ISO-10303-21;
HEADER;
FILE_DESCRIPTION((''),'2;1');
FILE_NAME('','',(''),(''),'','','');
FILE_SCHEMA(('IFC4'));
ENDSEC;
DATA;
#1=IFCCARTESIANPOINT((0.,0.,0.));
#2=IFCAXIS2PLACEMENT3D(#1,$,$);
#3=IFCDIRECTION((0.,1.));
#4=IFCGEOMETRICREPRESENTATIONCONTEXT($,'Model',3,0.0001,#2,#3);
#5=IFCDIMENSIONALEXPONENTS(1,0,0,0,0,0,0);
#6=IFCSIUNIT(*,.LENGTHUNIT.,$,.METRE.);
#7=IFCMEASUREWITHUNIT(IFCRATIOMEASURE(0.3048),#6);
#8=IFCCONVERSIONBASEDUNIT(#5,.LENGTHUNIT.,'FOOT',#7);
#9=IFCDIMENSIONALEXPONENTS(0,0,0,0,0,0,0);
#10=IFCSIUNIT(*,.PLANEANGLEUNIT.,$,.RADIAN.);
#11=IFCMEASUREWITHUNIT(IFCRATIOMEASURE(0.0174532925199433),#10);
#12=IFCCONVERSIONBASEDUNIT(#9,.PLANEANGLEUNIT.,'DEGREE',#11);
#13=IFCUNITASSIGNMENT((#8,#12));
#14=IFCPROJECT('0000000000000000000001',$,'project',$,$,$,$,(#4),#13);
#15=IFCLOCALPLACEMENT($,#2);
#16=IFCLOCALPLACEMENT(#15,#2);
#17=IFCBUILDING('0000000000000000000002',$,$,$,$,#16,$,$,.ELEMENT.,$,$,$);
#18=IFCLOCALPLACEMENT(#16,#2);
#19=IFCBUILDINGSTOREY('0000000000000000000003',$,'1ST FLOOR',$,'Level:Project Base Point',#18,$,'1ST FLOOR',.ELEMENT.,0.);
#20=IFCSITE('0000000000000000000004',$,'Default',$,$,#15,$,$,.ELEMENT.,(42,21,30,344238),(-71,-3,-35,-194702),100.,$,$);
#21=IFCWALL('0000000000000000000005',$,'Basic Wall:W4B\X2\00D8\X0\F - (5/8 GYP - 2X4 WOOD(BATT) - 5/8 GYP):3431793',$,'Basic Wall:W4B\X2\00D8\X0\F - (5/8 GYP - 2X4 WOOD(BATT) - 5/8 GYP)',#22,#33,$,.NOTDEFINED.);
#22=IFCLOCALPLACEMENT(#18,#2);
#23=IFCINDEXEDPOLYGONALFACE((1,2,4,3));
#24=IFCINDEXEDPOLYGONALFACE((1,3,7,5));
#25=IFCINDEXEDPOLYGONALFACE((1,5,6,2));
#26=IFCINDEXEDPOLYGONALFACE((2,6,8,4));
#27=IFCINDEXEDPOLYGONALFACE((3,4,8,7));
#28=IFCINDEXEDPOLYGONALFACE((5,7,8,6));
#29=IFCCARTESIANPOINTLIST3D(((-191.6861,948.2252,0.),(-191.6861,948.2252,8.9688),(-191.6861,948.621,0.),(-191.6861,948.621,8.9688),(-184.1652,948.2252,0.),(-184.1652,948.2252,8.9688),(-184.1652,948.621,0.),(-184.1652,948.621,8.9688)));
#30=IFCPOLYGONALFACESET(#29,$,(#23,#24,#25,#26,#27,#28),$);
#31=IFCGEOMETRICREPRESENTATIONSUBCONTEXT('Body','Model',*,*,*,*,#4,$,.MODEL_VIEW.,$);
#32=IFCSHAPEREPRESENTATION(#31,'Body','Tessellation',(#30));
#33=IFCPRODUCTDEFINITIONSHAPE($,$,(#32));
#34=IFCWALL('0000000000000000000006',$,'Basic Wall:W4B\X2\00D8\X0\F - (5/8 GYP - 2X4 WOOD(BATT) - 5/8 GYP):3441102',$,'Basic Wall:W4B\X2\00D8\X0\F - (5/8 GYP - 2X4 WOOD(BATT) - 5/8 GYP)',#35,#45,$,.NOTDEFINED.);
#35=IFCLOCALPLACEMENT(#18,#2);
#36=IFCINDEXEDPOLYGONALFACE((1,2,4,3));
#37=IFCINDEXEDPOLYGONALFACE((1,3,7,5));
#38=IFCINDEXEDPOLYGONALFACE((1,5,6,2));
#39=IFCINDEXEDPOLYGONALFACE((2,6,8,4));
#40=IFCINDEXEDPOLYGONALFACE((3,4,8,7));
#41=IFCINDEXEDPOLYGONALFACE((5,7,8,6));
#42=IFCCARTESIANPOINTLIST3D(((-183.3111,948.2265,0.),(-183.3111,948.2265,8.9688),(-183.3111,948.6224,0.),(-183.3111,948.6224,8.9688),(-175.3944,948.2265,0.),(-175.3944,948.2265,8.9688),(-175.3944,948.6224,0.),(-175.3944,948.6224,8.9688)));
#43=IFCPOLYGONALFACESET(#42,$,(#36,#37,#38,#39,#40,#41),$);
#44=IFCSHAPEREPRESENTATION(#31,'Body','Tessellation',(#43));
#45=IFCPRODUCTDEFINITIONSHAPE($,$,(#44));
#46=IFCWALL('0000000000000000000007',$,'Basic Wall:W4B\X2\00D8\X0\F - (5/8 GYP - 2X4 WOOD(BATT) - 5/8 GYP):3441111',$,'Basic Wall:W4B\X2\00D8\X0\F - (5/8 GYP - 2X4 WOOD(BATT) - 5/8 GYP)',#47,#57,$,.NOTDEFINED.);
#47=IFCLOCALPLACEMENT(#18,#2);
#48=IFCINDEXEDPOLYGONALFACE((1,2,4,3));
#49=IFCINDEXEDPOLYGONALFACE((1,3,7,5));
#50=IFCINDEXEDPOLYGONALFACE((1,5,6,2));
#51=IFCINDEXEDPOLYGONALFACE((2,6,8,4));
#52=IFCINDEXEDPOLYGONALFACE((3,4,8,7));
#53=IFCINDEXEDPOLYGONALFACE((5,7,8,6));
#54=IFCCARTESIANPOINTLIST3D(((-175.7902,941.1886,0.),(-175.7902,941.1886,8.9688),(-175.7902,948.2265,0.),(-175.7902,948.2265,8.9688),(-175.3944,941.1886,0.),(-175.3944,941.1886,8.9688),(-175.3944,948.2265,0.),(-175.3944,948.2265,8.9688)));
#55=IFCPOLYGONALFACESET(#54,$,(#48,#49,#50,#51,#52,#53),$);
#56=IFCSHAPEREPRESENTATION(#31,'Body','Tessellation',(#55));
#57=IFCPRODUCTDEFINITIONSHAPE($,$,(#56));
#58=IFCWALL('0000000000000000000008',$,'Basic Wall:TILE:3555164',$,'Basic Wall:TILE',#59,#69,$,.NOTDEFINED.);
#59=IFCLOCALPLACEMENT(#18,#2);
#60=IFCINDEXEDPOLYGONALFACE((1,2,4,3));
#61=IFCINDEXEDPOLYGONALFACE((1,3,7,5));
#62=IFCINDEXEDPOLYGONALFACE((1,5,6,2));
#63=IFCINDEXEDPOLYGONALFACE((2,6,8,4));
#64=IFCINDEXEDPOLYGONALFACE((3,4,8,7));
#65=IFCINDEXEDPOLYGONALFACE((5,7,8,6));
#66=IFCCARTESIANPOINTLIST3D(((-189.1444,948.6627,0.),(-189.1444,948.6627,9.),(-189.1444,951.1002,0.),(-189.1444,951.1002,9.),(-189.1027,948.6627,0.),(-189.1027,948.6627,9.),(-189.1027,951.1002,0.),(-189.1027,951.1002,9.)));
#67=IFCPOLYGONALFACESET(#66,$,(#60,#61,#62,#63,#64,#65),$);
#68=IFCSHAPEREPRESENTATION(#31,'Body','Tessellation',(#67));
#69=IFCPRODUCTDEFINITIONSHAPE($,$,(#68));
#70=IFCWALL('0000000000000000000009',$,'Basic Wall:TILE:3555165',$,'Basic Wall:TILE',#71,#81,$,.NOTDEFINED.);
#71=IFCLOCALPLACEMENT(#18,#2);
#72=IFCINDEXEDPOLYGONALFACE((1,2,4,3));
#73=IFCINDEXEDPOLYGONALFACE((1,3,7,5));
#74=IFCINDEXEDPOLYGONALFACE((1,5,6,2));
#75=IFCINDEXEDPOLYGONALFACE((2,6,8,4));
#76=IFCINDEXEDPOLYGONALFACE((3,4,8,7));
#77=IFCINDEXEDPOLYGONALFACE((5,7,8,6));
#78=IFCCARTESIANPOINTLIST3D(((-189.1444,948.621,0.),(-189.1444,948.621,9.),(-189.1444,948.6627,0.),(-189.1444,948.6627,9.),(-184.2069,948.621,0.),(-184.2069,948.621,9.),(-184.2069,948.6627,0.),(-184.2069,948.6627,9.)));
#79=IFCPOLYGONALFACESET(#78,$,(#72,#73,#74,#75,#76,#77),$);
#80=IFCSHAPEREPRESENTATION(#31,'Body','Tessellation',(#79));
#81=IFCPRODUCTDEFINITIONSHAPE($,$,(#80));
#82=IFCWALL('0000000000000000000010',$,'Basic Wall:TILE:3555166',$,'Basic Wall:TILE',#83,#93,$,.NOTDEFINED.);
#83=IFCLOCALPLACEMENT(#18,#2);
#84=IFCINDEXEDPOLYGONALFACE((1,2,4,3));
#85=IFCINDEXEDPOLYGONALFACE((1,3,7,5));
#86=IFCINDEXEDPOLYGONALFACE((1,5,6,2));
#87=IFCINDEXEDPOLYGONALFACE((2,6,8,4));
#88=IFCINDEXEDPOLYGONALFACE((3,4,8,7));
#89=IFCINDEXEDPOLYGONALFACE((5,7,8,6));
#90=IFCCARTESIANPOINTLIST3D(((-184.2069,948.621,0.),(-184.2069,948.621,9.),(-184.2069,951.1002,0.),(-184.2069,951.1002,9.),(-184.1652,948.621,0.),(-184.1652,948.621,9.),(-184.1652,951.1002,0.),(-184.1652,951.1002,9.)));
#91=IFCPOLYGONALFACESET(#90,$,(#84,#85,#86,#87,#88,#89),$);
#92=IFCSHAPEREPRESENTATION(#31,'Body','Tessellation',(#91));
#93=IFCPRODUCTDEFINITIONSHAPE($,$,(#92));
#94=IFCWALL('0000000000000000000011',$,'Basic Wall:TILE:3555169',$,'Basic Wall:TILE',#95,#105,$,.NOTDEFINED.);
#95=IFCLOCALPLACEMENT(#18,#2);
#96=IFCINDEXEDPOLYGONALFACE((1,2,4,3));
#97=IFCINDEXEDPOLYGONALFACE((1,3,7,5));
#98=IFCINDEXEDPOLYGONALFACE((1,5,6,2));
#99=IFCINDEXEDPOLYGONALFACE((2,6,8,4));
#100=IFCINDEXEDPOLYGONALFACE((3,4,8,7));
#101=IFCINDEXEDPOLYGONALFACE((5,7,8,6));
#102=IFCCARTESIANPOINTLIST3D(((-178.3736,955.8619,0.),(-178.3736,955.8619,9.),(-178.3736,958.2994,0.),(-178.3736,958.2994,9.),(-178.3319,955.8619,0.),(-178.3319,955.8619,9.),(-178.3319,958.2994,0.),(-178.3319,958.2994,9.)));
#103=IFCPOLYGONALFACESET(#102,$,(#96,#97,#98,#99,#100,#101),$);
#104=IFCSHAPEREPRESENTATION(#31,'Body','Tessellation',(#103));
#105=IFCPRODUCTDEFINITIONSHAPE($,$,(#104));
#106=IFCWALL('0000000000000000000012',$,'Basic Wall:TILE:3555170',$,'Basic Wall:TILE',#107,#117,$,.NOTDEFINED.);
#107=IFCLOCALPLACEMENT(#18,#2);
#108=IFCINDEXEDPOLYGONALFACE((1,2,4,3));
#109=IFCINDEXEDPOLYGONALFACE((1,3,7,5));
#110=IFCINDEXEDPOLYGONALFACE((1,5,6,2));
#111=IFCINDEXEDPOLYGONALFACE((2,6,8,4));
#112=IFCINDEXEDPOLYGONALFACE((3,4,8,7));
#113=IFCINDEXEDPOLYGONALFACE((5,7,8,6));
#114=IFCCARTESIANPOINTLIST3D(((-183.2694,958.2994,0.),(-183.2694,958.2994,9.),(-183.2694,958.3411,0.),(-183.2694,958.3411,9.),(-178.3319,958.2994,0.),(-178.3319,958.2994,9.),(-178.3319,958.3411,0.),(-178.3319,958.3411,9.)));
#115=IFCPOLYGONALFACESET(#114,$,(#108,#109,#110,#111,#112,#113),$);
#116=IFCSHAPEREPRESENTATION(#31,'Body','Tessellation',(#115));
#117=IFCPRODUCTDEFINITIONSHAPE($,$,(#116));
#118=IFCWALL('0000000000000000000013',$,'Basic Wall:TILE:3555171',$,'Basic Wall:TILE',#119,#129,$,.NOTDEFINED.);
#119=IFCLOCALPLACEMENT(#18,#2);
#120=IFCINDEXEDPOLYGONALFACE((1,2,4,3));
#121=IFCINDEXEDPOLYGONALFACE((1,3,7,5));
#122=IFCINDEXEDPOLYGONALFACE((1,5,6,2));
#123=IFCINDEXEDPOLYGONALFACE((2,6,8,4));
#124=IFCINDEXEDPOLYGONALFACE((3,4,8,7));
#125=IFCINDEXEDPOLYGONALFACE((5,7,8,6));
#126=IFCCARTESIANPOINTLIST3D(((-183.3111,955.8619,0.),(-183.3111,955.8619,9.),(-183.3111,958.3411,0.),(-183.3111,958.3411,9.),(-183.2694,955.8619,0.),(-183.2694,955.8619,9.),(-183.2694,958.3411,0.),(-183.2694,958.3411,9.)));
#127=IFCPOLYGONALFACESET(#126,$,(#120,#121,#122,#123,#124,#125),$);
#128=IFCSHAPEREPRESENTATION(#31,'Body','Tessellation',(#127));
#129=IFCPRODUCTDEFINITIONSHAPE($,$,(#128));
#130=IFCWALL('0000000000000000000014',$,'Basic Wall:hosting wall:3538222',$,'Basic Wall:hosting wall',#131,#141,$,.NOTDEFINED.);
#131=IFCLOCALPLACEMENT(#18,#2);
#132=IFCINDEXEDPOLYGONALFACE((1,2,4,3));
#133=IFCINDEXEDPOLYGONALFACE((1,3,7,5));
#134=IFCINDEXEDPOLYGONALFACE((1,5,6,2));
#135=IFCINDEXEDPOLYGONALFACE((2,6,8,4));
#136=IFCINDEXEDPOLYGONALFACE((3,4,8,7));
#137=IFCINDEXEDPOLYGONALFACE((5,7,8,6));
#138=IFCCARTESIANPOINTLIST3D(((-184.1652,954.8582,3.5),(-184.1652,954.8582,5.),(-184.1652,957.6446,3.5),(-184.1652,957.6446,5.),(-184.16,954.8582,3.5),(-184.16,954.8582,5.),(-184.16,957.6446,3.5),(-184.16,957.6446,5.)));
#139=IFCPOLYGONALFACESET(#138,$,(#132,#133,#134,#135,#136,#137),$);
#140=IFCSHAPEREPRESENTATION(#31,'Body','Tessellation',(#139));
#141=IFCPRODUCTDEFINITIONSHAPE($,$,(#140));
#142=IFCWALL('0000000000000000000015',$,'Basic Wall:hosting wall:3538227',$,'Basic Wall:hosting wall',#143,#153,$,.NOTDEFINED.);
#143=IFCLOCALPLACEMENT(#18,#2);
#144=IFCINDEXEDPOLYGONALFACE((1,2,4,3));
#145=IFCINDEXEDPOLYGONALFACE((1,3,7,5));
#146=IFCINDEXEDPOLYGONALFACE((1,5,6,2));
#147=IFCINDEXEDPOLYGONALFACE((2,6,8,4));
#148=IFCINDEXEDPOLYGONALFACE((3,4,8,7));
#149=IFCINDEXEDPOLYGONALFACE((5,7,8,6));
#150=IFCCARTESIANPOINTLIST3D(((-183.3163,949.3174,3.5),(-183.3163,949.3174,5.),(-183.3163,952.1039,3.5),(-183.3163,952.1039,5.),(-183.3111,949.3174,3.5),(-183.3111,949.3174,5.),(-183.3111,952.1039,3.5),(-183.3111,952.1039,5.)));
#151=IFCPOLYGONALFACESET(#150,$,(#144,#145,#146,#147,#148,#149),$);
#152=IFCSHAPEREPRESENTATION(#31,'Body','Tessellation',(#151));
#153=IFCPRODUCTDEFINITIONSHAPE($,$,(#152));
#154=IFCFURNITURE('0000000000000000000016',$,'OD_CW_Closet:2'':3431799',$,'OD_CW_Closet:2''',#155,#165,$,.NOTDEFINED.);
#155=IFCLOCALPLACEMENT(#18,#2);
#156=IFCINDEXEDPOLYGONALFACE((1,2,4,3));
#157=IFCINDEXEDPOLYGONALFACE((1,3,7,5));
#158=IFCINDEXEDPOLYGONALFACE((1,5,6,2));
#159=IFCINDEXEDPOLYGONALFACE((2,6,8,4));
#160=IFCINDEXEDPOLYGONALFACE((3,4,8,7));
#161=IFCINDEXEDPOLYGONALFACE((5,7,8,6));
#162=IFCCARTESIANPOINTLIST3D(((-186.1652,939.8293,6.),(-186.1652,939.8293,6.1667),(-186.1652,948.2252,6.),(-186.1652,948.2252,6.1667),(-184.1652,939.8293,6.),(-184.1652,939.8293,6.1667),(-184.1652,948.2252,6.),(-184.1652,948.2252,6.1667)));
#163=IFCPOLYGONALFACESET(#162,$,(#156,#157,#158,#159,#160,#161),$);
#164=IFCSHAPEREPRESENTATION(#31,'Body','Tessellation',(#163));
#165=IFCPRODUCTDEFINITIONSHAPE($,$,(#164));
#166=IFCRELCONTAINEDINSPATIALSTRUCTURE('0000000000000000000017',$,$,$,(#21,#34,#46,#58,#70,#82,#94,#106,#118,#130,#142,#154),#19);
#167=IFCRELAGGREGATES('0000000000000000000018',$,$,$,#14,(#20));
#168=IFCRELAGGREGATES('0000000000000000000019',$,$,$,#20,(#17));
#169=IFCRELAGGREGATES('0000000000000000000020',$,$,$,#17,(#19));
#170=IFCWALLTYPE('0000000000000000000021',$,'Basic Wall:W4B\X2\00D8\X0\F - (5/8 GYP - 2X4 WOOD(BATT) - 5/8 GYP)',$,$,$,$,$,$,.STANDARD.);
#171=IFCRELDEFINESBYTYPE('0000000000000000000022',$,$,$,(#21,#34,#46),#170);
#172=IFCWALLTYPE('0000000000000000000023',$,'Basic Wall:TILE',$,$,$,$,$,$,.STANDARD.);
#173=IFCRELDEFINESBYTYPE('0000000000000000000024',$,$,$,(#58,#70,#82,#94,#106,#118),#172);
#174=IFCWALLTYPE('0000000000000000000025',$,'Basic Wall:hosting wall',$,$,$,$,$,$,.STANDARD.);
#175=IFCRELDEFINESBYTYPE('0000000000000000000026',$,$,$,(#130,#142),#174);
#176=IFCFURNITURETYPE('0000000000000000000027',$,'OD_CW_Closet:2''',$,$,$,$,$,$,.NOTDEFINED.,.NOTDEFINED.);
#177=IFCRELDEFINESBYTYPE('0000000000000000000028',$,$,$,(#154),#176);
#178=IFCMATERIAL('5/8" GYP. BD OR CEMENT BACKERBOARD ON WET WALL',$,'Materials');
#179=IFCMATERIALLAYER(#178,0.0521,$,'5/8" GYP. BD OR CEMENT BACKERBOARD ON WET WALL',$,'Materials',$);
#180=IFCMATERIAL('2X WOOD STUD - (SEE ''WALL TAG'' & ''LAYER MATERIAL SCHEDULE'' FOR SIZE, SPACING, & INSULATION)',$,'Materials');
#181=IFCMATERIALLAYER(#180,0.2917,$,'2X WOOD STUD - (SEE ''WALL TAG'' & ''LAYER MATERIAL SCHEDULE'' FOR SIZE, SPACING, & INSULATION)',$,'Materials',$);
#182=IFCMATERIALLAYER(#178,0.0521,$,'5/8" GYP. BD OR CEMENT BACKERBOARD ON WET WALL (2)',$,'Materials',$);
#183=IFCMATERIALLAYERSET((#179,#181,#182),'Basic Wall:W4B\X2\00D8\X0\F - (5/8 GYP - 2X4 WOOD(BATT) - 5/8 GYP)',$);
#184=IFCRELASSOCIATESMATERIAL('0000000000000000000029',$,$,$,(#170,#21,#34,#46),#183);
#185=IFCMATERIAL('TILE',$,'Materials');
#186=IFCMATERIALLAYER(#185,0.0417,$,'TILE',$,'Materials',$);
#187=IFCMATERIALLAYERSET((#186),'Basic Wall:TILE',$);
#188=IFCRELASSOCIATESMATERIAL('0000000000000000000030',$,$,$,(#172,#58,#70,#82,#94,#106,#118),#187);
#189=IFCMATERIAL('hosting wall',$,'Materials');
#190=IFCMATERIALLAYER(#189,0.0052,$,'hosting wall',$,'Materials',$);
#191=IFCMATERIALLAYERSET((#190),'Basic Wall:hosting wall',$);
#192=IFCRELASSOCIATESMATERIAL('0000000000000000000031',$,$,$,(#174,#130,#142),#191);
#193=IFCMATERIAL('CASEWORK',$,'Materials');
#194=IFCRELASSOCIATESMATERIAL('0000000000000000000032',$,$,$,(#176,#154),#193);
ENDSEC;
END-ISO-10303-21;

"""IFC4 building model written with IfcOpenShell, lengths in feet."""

from ifc_helpers import new_model, entity, si_unit, converted_unit, direction, frame, frame_2d, origin, place, context, subcontext, project, spatial, rectangle, extrude, source, transform, mapped, material, layer, layer_set, layer_usage, type_object, type_shapes, element, save


model = new_model("IFC4")

# Units and contexts
model_context = context("Model", 3, precision=0.0001, world=origin(), true_north=direction((0.0, 1.0)))
body_context = subcontext(model_context, "Body", "Model", "MODEL_VIEW")
ifc_project = project(units=[converted_unit("LENGTHUNIT", "FOOT", entity("IfcRatioMeasure", 0.3048), si_unit("LENGTHUNIT", "METRE"), dimensions=[1, 0, 0, 0, 0, 0, 0]), converted_unit("PLANEANGLEUNIT", "DEGREE", entity("IfcRatioMeasure", 0.0174532925199433), si_unit("PLANEANGLEUNIT", "RADIAN"), dimensions=[0, 0, 0, 0, 0, 0, 0])], contexts=[model_context])

# Site, building, storey
site_placement = place(None, origin())
site = spatial("IfcSite", under=ifc_project, at=site_placement, Name="Default", CompositionType="ELEMENT", RefLatitude=(42, 21, 30, 344238), RefLongitude=(-71, -3, -35, -194702), RefElevation=100.0)
building_placement = place(site_placement, origin())
building = spatial("IfcBuilding", under=site, at=building_placement, CompositionType="ELEMENT")
storey_placement = place(building_placement, origin())
storey = spatial("IfcBuildingStorey", under=building, at=storey_placement, Name="1ST FLOOR", ObjectType="Level:Project Base Point", LongName="1ST FLOOR", CompositionType="ELEMENT", Elevation=0.0)

# Walls
ifc_material_1 = material(Name="5/8\" GYP. BD OR CEMENT BACKERBOARD ON WET WALL", Category="Materials")
ifc_layer_1 = layer(ifc_material_1, 0.0521, Name="5/8\" GYP. BD OR CEMENT BACKERBOARD ON WET WALL", Category="Materials")
ifc_material_2 = material(Name="2X WOOD STUD - (SEE 'WALL TAG' & 'LAYER MATERIAL SCHEDULE' FOR SIZE, SPACING, & INSULATION)", Category="Materials")
ifc_layer_2 = layer(ifc_material_2, 0.2917, Name="2X WOOD STUD - (SEE 'WALL TAG' & 'LAYER MATERIAL SCHEDULE' FOR SIZE, SPACING, & INSULATION)", Category="Materials")
ifc_layer_3 = layer(ifc_material_1, 0.0521, Name="5/8\" GYP. BD OR CEMENT BACKERBOARD ON WET WALL (2)", Category="Materials")
ifc_layer_set_1 = layer_set([ifc_layer_1, ifc_layer_2, ifc_layer_3], Name="Basic Wall:W4BØF - (5/8 GYP - 2X4 WOOD(BATT) - 5/8 GYP)")
ifc_layer_usage_1 = layer_usage(ifc_layer_set_1, "AXIS2", "NEGATIVE", 0.1979)
wall_type_1 = type_object("IfcWallType", Name="Basic Wall:W4BØF - (5/8 GYP - 2X4 WOOD(BATT) - 5/8 GYP)", PredefinedType="STANDARD", material=ifc_layer_set_1)
wall_1_placement = place(storey_placement, frame((-184.1652, 948.4231, 0.0), z_axis=(0.0, 0.0, 1.0), x_axis=(-1.0, 0.0, 0.0)))
element("IfcWall", 1, at=wall_1_placement, inside=storey, type_object=wall_type_1, material=ifc_layer_usage_1, Name="Basic Wall:W4BØF - (5/8 GYP - 2X4 WOOD(BATT) - 5/8 GYP):3431793", ObjectType="Basic Wall:W4BØF - (5/8 GYP - 2X4 WOOD(BATT) - 5/8 GYP)", PredefinedType="NOTDEFINED", context=body_context, shape_type="SweptSolid", body=[
    extrude(rectangle(XDim=7.5208, YDim=0.3958, at=frame_2d((3.7604, 0.0), x_axis=(-1.0, 0.0))), origin(), (0.0, 0.0, 1.0), 8.9688),
])
ifc_layer_usage_2 = layer_usage(ifc_layer_set_1, "AXIS2", "POSITIVE", -0.1979)
wall_2_placement = place(storey_placement, frame((-183.3111, 948.4244, 0.0)))
element("IfcWall", 2, at=wall_2_placement, inside=storey, type_object=wall_type_1, material=ifc_layer_usage_2, Name="Basic Wall:W4BØF - (5/8 GYP - 2X4 WOOD(BATT) - 5/8 GYP):3441102", ObjectType="Basic Wall:W4BØF - (5/8 GYP - 2X4 WOOD(BATT) - 5/8 GYP)", PredefinedType="NOTDEFINED", context=body_context, shape_type="SweptSolid", body=[
    extrude(rectangle(XDim=7.9167, YDim=0.3958, at=frame_2d((3.9583, 0.0), x_axis=(-1.0, 0.0))), origin(), (0.0, 0.0, 1.0), 8.9688),
])

# Walls
ifc_layer_usage_3 = layer_usage(ifc_layer_set_1, "AXIS2", "POSITIVE", -0.1979)
wall_3_placement = place(storey_placement, frame((-175.5923, 941.1886, 0.0), z_axis=(0.0, 0.0, 1.0), x_axis=(0.0, 1.0, 0.0)))
element("IfcWall", 3, at=wall_3_placement, inside=storey, type_object=wall_type_1, material=ifc_layer_usage_3, Name="Basic Wall:W4BØF - (5/8 GYP - 2X4 WOOD(BATT) - 5/8 GYP):3441111", ObjectType="Basic Wall:W4BØF - (5/8 GYP - 2X4 WOOD(BATT) - 5/8 GYP)", PredefinedType="NOTDEFINED", context=body_context, shape_type="SweptSolid", body=[
    extrude(rectangle(XDim=7.038, YDim=0.3958, at=frame_2d((3.519, 0.0), x_axis=(-1.0, 0.0))), origin(), (0.0, 0.0, 1.0), 8.9688),
])
ifc_material_3 = material(Name="TILE", Category="Materials")
ifc_layer_4 = layer(ifc_material_3, 0.0417, Name="TILE", Category="Materials")
ifc_layer_set_2 = layer_set([ifc_layer_4], Name="Basic Wall:TILE")
ifc_layer_usage_4 = layer_usage(ifc_layer_set_2, "AXIS2", "POSITIVE", -0.0208)
wall_type_2 = type_object("IfcWallType", Name="Basic Wall:TILE", PredefinedType="STANDARD", material=ifc_layer_set_2)
wall_4_placement = place(storey_placement, frame((-189.1236, 951.1002, 0.0), z_axis=(0.0, 0.0, 1.0), x_axis=(0.0, -1.0, 0.0)))
element("IfcWall", 4, at=wall_4_placement, inside=storey, type_object=wall_type_2, material=ifc_layer_usage_4, Name="Basic Wall:TILE:3555164", ObjectType="Basic Wall:TILE", PredefinedType="NOTDEFINED", context=body_context, shape_type="SweptSolid", body=[
    extrude(rectangle(XDim=2.4375, YDim=0.0417, at=frame_2d((1.2187, 0.0), x_axis=(-1.0, 0.0))), origin(), (0.0, 0.0, 1.0), 9.0),
])
ifc_layer_usage_5 = layer_usage(ifc_layer_set_2, "AXIS2", "POSITIVE", -0.0208)
wall_5_placement = place(storey_placement, frame((-189.1444, 948.6418, 0.0)))
element("IfcWall", 5, at=wall_5_placement, inside=storey, type_object=wall_type_2, material=ifc_layer_usage_5, Name="Basic Wall:TILE:3555165", ObjectType="Basic Wall:TILE", PredefinedType="NOTDEFINED", context=body_context, shape_type="SweptSolid", body=[
    extrude(rectangle(XDim=4.9375, YDim=0.0417, at=frame_2d((2.4688, 0.0), x_axis=(-1.0, 0.0))), origin(), (0.0, 0.0, 1.0), 9.0),
])
ifc_layer_usage_6 = layer_usage(ifc_layer_set_2, "AXIS2", "POSITIVE", -0.0208)
wall_6_placement = place(storey_placement, frame((-184.1861, 948.621, 0.0), z_axis=(0.0, 0.0, 1.0), x_axis=(0.0, 1.0, 0.0)))
element("IfcWall", 6, at=wall_6_placement, inside=storey, type_object=wall_type_2, material=ifc_layer_usage_6, Name="Basic Wall:TILE:3555166", ObjectType="Basic Wall:TILE", PredefinedType="NOTDEFINED", context=body_context, shape_type="SweptSolid", body=[
    extrude(rectangle(XDim=2.4792, YDim=0.0417, at=frame_2d((1.2396, 0.0), x_axis=(-1.0, 0.0))), origin(), (0.0, 0.0, 1.0), 9.0),
])
ifc_layer_usage_7 = layer_usage(ifc_layer_set_2, "AXIS2", "POSITIVE", -0.0208)
wall_7_placement = place(storey_placement, frame((-178.3527, 955.8619, 0.0), z_axis=(0.0, 0.0, 1.0), x_axis=(0.0, 1.0, 0.0)))
element("IfcWall", 7, at=wall_7_placement, inside=storey, type_object=wall_type_2, material=ifc_layer_usage_7, Name="Basic Wall:TILE:3555169", ObjectType="Basic Wall:TILE", PredefinedType="NOTDEFINED", context=body_context, shape_type="SweptSolid", body=[
    extrude(rectangle(XDim=2.4375, YDim=0.0417, at=frame_2d((1.2187, 0.0), x_axis=(-1.0, 0.0))), origin(), (0.0, 0.0, 1.0), 9.0),
])
ifc_layer_usage_8 = layer_usage(ifc_layer_set_2, "AXIS2", "POSITIVE", -0.0208)
wall_8_placement = place(storey_placement, frame((-178.3319, 958.3203, 0.0), z_axis=(0.0, 0.0, 1.0), x_axis=(-1.0, 0.0, 0.0)))
element("IfcWall", 8, at=wall_8_placement, inside=storey, type_object=wall_type_2, material=ifc_layer_usage_8, Name="Basic Wall:TILE:3555170", ObjectType="Basic Wall:TILE", PredefinedType="NOTDEFINED", context=body_context, shape_type="SweptSolid", body=[
    extrude(rectangle(XDim=4.9375, YDim=0.0417, at=frame_2d((2.4688, 0.0), x_axis=(-1.0, 0.0))), origin(), (0.0, 0.0, 1.0), 9.0),
])
ifc_layer_usage_9 = layer_usage(ifc_layer_set_2, "AXIS2", "POSITIVE", -0.0208)
wall_9_placement = place(storey_placement, frame((-183.2902, 958.3411, 0.0), z_axis=(0.0, 0.0, 1.0), x_axis=(0.0, -1.0, 0.0)))
element("IfcWall", 9, at=wall_9_placement, inside=storey, type_object=wall_type_2, material=ifc_layer_usage_9, Name="Basic Wall:TILE:3555171", ObjectType="Basic Wall:TILE", PredefinedType="NOTDEFINED", context=body_context, shape_type="SweptSolid", body=[
    extrude(rectangle(XDim=2.4792, YDim=0.0417, at=frame_2d((1.2396, 0.0), x_axis=(-1.0, 0.0))), origin(), (0.0, 0.0, 1.0), 9.0),
])
ifc_material_4 = material(Name="hosting wall", Category="Materials")
ifc_layer_5 = layer(ifc_material_4, 0.0052, Name="hosting wall", Category="Materials")
ifc_layer_set_3 = layer_set([ifc_layer_5], Name="Basic Wall:hosting wall")
ifc_layer_usage_10 = layer_usage(ifc_layer_set_3, "AXIS2", "NEGATIVE", 0.0026)
wall_type_3 = type_object("IfcWallType", Name="Basic Wall:hosting wall", PredefinedType="STANDARD", material=ifc_layer_set_3)
wall_10_placement = place(storey_placement, frame((-184.1626, 957.6446, 3.5), z_axis=(0.0, 0.0, 1.0), x_axis=(0.0, -1.0, 0.0)))
element("IfcWall", 10, at=wall_10_placement, inside=storey, type_object=wall_type_3, material=ifc_layer_usage_10, Name="Basic Wall:hosting wall:3538222", ObjectType="Basic Wall:hosting wall", PredefinedType="NOTDEFINED", context=body_context, shape_type="SweptSolid", body=[
    extrude(rectangle(XDim=2.7865, YDim=0.0052, at=frame_2d((1.3932, 0.0), x_axis=(-1.0, 0.0))), origin(), (0.0, 0.0, 1.0), 1.5),
])
ifc_layer_usage_11 = layer_usage(ifc_layer_set_3, "AXIS2", "NEGATIVE", 0.0026)
wall_11_placement = place(storey_placement, frame((-183.3137, 949.3174, 3.5), z_axis=(0.0, 0.0, 1.0), x_axis=(0.0, 1.0, 0.0)))
element("IfcWall", 11, at=wall_11_placement, inside=storey, type_object=wall_type_3, material=ifc_layer_usage_11, Name="Basic Wall:hosting wall:3538227", ObjectType="Basic Wall:hosting wall", PredefinedType="NOTDEFINED", context=body_context, shape_type="SweptSolid", body=[
    extrude(rectangle(XDim=2.7865, YDim=0.0052, at=frame_2d((1.3932, 0.0), x_axis=(-1.0, 0.0))), origin(), (0.0, 0.0, 1.0), 1.5),
])

# Furniture
ifc_material_5 = material(Name="CASEWORK", Category="Materials")
furniture_type_1 = type_object("IfcFurnitureType", Name="OD_CW_Closet:2'", AssemblyPlace="NOTDEFINED", PredefinedType="NOTDEFINED", material=ifc_material_5)
shared_shape_1 = source(origin(), body_context, "Body", "SweptSolid", [
    extrude(rectangle(XDim=2.0, YDim=8.3958, at=frame_2d((0.0, 0.0), x_axis=(1.0, 0.0))), frame((4.1979, 1.0, 0.0), z_axis=(0.0, 0.0, 1.0), x_axis=(0.0, -1.0, 0.0)), (0.0, 0.0, 1.0), 0.1667),
])
type_shapes(furniture_type_1, [shared_shape_1])
furniture_1_placement = place(storey_placement, frame((-186.1652, 948.2252, 6.0), z_axis=(0.0, 0.0, 1.0), x_axis=(0.0, -1.0, 0.0)))
element("IfcFurniture", 12, at=furniture_1_placement, inside=storey, type_object=furniture_type_1, material=ifc_material_5, Name="OD_CW_Closet:2':3431799", ObjectType="OD_CW_Closet:2'", PredefinedType="NOTDEFINED", context=body_context, shape_type="MappedRepresentation", body=[
    mapped(shared_shape_1, transform((0.0, 0.0, 0.0), scale=1.0)),
])

save(model, "model.ifc")
